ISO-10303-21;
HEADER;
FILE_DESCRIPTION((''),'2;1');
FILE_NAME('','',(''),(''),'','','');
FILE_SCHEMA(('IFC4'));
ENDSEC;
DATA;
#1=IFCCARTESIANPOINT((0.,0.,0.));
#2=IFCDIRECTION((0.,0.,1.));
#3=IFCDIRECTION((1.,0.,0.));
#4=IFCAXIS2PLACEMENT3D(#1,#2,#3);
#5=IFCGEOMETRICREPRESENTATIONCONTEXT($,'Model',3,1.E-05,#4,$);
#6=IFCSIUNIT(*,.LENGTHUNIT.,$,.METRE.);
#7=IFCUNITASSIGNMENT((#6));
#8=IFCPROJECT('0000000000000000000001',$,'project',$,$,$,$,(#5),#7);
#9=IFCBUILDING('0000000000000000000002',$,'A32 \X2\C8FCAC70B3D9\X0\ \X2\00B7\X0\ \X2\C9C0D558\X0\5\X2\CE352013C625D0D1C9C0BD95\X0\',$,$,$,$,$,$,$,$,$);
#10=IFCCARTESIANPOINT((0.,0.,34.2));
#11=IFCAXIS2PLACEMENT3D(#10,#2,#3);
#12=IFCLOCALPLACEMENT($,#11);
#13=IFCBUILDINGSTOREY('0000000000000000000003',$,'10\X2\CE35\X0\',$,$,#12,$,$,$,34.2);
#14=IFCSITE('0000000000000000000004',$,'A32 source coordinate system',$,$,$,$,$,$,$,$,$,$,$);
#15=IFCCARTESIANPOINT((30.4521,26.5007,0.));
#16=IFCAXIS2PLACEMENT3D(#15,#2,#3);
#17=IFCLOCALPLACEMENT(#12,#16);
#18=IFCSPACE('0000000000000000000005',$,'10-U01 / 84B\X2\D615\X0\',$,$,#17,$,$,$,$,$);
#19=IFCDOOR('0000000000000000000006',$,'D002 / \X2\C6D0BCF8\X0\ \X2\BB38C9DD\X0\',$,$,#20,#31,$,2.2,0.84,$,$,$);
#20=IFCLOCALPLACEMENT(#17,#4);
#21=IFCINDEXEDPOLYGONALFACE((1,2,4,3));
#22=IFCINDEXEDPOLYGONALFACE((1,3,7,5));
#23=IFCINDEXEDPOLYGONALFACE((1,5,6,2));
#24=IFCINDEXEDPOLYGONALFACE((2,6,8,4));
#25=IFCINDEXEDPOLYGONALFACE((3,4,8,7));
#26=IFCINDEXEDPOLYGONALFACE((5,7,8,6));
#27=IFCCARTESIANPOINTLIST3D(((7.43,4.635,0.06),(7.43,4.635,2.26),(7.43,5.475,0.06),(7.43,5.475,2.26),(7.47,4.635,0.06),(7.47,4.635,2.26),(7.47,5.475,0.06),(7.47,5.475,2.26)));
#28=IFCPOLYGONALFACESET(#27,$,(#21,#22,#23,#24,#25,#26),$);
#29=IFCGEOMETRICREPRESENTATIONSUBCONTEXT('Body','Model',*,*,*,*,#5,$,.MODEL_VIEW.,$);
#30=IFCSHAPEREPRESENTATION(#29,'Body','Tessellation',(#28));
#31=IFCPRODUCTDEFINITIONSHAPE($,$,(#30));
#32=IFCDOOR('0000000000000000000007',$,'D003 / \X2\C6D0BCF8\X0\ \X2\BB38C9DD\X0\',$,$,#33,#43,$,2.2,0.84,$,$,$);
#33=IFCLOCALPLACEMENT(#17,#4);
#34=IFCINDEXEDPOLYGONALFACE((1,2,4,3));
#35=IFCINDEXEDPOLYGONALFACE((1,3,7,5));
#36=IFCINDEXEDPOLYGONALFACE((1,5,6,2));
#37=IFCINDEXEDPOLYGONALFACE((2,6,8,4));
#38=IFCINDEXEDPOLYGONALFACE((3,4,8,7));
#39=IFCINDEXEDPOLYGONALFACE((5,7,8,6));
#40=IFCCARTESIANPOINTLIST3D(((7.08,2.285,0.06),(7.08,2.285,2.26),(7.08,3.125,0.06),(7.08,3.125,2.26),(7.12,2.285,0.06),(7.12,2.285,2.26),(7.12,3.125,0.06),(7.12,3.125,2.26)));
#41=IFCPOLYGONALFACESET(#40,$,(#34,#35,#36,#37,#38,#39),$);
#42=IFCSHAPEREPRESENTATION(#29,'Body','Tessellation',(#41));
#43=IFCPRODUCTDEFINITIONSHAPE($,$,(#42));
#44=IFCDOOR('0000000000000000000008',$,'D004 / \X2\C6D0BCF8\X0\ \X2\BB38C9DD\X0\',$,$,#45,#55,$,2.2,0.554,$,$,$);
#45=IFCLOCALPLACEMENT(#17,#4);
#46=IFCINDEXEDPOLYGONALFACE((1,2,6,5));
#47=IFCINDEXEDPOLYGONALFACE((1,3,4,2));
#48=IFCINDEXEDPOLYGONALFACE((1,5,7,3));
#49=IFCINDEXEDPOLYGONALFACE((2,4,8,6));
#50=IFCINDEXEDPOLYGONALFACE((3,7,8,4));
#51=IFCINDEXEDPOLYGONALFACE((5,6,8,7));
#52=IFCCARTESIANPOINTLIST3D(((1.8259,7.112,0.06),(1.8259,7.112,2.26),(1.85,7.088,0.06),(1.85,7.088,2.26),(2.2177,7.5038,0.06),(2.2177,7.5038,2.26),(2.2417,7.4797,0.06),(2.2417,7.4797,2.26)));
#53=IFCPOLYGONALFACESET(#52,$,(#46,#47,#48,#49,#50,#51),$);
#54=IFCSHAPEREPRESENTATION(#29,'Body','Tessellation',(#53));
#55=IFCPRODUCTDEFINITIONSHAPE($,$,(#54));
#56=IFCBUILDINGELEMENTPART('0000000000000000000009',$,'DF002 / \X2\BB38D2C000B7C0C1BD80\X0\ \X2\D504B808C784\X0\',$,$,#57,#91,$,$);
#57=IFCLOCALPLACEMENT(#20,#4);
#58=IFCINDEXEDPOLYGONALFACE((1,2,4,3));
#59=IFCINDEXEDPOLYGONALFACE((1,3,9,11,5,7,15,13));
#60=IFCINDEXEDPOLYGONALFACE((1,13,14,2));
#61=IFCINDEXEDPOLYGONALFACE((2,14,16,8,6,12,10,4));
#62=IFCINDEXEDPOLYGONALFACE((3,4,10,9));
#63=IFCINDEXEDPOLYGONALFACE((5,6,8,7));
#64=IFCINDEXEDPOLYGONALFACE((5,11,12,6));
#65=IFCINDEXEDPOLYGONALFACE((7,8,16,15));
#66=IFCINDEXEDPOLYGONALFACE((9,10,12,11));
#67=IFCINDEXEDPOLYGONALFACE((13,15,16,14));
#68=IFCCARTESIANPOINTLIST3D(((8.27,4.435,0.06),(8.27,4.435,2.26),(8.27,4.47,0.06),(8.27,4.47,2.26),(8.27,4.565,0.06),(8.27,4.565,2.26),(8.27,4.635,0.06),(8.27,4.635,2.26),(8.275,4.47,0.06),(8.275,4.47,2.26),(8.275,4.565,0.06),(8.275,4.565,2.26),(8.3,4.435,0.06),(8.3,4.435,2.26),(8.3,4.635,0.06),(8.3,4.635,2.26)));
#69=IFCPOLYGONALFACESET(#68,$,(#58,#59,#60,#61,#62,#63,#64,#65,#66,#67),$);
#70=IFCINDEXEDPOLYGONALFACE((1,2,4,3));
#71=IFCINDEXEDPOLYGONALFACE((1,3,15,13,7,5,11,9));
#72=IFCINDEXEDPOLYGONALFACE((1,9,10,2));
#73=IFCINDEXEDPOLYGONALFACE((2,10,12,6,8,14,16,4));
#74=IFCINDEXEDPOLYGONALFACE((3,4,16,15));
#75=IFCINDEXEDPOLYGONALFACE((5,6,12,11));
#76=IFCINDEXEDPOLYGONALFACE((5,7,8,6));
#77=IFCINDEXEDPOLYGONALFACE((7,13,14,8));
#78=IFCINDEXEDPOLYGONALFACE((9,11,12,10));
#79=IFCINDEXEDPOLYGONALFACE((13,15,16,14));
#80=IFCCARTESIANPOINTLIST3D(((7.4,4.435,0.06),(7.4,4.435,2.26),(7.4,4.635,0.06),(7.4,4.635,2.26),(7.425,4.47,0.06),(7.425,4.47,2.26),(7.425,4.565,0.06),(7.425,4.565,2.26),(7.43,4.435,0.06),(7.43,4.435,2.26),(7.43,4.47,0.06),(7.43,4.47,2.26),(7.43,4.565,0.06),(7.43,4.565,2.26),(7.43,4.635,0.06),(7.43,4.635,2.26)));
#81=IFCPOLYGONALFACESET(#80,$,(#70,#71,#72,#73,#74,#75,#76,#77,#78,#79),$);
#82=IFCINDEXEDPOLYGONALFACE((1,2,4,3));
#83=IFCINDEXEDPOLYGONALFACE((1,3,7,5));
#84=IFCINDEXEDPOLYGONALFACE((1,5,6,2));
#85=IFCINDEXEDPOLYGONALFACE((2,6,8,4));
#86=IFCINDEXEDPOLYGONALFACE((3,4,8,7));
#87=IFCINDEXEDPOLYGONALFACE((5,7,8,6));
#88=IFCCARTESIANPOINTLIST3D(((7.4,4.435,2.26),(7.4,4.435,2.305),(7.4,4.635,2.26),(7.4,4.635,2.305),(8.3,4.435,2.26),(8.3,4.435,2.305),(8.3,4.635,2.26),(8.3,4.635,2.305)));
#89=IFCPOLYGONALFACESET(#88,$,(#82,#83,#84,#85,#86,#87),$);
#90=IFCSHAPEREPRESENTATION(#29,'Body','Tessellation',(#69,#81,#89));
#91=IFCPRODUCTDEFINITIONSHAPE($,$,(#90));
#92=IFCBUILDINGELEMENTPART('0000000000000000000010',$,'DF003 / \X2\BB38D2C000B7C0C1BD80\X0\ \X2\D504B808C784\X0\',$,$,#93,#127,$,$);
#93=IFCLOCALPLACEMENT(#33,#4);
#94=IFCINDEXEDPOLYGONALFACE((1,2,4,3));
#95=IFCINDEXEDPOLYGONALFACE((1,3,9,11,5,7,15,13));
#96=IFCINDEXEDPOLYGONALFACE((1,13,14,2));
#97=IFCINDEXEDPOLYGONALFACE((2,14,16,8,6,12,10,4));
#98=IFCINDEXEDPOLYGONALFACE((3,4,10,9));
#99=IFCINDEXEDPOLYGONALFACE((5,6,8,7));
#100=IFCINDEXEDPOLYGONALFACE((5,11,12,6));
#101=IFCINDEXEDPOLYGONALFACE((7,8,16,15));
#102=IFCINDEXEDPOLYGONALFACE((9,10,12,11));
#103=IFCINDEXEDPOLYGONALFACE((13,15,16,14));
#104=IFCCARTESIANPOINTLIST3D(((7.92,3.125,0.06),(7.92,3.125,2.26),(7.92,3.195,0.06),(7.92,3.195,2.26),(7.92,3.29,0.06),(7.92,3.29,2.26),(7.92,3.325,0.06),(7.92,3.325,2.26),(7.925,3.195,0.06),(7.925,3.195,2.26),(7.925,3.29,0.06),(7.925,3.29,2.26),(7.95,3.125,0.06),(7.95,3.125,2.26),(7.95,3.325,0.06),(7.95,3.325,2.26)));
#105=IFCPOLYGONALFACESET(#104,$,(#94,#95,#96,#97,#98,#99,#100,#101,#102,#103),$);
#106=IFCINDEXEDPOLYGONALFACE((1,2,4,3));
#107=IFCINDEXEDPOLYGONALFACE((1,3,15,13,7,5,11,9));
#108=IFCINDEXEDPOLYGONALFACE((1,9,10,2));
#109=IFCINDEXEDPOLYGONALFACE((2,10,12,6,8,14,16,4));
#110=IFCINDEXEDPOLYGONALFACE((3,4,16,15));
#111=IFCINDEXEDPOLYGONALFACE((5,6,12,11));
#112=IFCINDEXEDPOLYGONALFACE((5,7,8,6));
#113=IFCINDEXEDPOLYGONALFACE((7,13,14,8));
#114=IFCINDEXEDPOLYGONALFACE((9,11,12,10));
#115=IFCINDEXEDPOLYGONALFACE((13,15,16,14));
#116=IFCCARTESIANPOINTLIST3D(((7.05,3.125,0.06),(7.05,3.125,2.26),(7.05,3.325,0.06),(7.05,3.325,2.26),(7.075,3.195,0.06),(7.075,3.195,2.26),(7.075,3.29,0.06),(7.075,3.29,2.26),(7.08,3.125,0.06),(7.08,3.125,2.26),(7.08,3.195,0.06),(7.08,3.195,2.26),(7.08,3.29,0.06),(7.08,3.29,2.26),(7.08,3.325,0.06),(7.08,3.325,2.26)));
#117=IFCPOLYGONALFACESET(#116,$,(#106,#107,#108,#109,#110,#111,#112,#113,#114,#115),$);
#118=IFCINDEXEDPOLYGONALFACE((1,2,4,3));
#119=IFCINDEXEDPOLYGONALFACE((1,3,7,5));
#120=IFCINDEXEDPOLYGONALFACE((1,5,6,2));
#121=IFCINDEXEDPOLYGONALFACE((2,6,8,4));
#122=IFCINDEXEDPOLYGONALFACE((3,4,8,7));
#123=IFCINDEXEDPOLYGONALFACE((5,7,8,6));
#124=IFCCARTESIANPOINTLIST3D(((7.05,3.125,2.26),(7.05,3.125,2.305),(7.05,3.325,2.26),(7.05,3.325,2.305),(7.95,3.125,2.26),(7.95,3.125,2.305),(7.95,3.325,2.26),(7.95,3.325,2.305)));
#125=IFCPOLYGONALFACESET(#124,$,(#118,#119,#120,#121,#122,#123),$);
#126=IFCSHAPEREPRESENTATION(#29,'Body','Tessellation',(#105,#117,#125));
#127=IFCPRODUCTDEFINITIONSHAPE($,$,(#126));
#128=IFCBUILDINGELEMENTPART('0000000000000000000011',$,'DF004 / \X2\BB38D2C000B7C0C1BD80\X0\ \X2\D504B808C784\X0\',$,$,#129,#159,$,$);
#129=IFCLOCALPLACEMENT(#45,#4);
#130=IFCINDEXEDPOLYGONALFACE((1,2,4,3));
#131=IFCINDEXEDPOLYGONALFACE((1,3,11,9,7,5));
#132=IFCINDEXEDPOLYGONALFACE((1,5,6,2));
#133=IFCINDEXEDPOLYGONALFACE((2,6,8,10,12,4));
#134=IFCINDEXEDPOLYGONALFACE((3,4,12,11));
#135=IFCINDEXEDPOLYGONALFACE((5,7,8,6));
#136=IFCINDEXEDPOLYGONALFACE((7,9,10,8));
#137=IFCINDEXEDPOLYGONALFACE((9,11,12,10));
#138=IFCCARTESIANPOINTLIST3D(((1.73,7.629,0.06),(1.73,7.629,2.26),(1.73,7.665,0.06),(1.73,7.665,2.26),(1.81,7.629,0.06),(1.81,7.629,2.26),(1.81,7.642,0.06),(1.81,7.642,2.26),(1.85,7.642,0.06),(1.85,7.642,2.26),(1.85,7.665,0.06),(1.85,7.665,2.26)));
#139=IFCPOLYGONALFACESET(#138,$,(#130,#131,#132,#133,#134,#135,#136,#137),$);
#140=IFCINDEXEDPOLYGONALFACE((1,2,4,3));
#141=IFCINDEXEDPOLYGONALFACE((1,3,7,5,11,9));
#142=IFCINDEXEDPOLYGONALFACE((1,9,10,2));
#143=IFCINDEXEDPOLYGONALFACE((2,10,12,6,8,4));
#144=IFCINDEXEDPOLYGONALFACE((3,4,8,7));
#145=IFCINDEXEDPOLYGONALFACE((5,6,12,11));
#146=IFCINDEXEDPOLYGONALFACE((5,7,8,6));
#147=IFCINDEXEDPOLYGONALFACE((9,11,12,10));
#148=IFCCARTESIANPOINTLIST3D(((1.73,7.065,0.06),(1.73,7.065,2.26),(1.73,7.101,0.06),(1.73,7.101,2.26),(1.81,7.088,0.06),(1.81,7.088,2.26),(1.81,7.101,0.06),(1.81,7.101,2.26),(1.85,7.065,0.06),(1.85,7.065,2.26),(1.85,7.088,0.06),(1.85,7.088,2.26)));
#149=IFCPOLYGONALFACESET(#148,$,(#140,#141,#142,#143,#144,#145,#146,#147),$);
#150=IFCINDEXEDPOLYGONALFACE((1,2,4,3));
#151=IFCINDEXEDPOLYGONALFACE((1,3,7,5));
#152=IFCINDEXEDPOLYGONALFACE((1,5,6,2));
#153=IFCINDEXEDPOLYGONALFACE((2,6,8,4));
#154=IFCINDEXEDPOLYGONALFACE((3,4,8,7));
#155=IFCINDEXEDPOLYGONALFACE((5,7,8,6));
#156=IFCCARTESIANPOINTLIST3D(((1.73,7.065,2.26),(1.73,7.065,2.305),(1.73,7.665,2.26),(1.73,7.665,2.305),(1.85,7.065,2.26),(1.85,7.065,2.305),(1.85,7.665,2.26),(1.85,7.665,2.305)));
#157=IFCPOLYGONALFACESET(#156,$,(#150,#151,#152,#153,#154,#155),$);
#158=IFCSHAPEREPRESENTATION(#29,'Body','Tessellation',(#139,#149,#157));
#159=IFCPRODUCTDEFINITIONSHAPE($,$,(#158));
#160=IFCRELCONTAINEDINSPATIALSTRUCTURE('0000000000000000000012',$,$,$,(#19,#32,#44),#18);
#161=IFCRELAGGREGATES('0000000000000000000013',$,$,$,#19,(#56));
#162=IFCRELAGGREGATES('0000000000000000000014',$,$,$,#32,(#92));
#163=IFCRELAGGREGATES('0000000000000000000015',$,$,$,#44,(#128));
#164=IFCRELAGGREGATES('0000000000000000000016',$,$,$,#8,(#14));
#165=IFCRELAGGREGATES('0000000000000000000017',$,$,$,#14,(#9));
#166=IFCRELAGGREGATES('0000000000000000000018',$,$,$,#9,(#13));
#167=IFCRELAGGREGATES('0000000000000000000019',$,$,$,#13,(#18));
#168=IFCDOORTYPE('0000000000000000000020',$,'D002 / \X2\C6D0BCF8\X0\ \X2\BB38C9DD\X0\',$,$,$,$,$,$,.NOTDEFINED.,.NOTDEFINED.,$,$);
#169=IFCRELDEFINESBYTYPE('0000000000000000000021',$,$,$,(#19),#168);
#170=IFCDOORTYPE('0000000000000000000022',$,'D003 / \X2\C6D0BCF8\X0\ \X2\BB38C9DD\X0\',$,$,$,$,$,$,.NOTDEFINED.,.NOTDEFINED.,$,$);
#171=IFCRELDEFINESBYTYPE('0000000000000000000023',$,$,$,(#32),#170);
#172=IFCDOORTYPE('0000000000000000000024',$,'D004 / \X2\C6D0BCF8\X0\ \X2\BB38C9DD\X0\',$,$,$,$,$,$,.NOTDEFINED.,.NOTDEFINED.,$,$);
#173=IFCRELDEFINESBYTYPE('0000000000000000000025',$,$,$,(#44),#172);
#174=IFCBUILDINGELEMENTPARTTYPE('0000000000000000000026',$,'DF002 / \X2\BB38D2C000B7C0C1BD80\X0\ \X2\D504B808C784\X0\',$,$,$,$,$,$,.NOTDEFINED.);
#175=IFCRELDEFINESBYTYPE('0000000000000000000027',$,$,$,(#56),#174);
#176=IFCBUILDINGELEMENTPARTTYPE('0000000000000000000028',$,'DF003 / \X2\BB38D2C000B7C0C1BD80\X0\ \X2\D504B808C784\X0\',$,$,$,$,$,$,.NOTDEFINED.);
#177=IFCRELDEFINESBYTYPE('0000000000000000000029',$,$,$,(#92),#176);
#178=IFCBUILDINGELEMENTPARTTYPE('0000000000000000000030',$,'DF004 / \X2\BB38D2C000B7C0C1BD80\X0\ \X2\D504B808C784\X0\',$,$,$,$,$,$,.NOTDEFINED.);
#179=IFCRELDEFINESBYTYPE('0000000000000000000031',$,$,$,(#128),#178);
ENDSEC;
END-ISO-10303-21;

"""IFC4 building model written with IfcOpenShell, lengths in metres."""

from ifc_helpers import new_model, si_unit, frame, origin, origin_with_axes, place, context, subcontext, project, spatial, polyline, outline, extrude, source, transform, mapped, type_object, type_shapes, element, aggregate, save


model = new_model("IFC4")

# Units and contexts
model_context = context("Model", 3, precision=1e-05, world=origin_with_axes())
body_context = subcontext(model_context, "Body", "Model", "MODEL_VIEW")
ifc_project = project(units=[si_unit("LENGTHUNIT", "METRE")], contexts=[model_context])

# Site, building, storey, space
storey_placement = place(None, frame((0.0, 0.0, 34.2), z_axis=(0.0, 0.0, 1.0), x_axis=(1.0, 0.0, 0.0)))
space_placement = place(storey_placement, frame((30.4521, 26.5007, 0.0), z_axis=(0.0, 0.0, 1.0), x_axis=(1.0, 0.0, 0.0)))
site = spatial("IfcSite", under=ifc_project, Name="A32 source coordinate system")
building = spatial("IfcBuilding", under=site, Name="A32 주거동 · 지하5층–옥탑지붕")
storey = spatial("IfcBuildingStorey", under=building, at=storey_placement, Name="10층", Elevation=34.2)
space = spatial("IfcSpace", under=storey, at=space_placement, Name="10-U01 / 84B형")

# Doors
door_type_1 = type_object("IfcDoorType", Name="D002 / 원본 문짝", OperationType="NOTDEFINED", PredefinedType="NOTDEFINED")
shared_shape_1 = source(origin(), body_context, "Body", "SweptSolid", [
    extrude(outline(polyline([(7.43, 4.635), (7.43, 5.475), (7.47, 5.475), (7.47, 4.635), (7.43, 4.635)])), frame((0.0, 0.0, 0.06)), (0.0, 0.0, 1.0), 2.2),
])
type_shapes(door_type_1, [shared_shape_1])
door_1_placement = place(space_placement, origin_with_axes())
door_1 = element("IfcDoor", 1, at=door_1_placement, inside=space, type_object=door_type_1, Name="D002 / 원본 문짝", OverallHeight=2.2, OverallWidth=0.84, context=body_context, shape_type="MappedRepresentation", body=[
    mapped(shared_shape_1, transform((0.0, 0.0, 0.0), scale=1.0)),
])
door_type_2 = type_object("IfcDoorType", Name="D003 / 원본 문짝", OperationType="NOTDEFINED", PredefinedType="NOTDEFINED")
shared_shape_2 = source(origin(), body_context, "Body", "SweptSolid", [
    extrude(outline(polyline([(7.12, 2.285), (7.08, 2.285), (7.08, 3.125), (7.12, 3.125), (7.12, 2.285)])), frame((0.0, 0.0, 0.06)), (0.0, 0.0, 1.0), 2.2),
])
type_shapes(door_type_2, [shared_shape_2])
door_2_placement = place(space_placement, origin_with_axes())
door_2 = element("IfcDoor", 2, at=door_2_placement, inside=space, type_object=door_type_2, Name="D003 / 원본 문짝", OverallHeight=2.2, OverallWidth=0.84, context=body_context, shape_type="MappedRepresentation", body=[
    mapped(shared_shape_2, transform((0.0, 0.0, 0.0), scale=1.0)),
])
door_type_3 = type_object("IfcDoorType", Name="D004 / 원본 문짝", OperationType="NOTDEFINED", PredefinedType="NOTDEFINED")
shared_shape_3 = source(origin(), body_context, "Body", "SweptSolid", [
    extrude(outline(polyline([(2.2177, 7.5038), (2.2417, 7.4797), (1.85, 7.088), (1.8259, 7.112), (2.2177, 7.5038)])), frame((0.0, 0.0, 0.06)), (0.0, 0.0, 1.0), 2.2),
])
type_shapes(door_type_3, [shared_shape_3])
door_3_placement = place(space_placement, origin_with_axes())
door_3 = element("IfcDoor", 3, at=door_3_placement, inside=space, type_object=door_type_3, Name="D004 / 원본 문짝", OverallHeight=2.2, OverallWidth=0.554, context=body_context, shape_type="MappedRepresentation", body=[
    mapped(shared_shape_3, transform((0.0, 0.0, 0.0), scale=1.0)),
])

# Building element parts
building_element_part_type_1 = type_object("IfcBuildingElementPartType", Name="DF002 / 문틀·상부 프레임", PredefinedType="NOTDEFINED")
shared_shape_4 = source(origin(), body_context, "Body", "SweptSolid", [
    extrude(outline(polyline([(8.3, 4.435), (8.27, 4.435), (8.27, 4.47), (8.275, 4.47), (8.275, 4.565), (8.27, 4.565), (8.27, 4.635), (8.3, 4.635), (8.3, 4.435)])), frame((0.0, 0.0, 0.06)), (0.0, 0.0, 1.0), 2.2),
    extrude(outline(polyline([(7.43, 4.635), (7.43, 4.565), (7.425, 4.565), (7.425, 4.47), (7.43, 4.47), (7.43, 4.435), (7.4, 4.435), (7.4, 4.635), (7.43, 4.635)])), frame((0.0, 0.0, 0.06)), (0.0, 0.0, 1.0), 2.2),
    extrude(outline(polyline([(7.4, 4.435), (7.4, 4.635), (8.3, 4.635), (8.3, 4.435), (7.4, 4.435)])), frame((0.0, 0.0, 2.26)), (0.0, 0.0, 1.0), 0.045),
])
type_shapes(building_element_part_type_1, [shared_shape_4])
building_element_part_1_placement = place(door_1_placement, origin_with_axes())
building_element_part_1 = element("IfcBuildingElementPart", 4, at=building_element_part_1_placement, type_object=building_element_part_type_1, Name="DF002 / 문틀·상부 프레임", context=body_context, shape_type="MappedRepresentation", body=[
    mapped(shared_shape_4, transform((0.0, 0.0, 0.0), scale=1.0)),
])
aggregate(door_1, [building_element_part_1])
building_element_part_type_2 = type_object("IfcBuildingElementPartType", Name="DF003 / 문틀·상부 프레임", PredefinedType="NOTDEFINED")
shared_shape_5 = source(origin(), body_context, "Body", "SweptSolid", [
    extrude(outline(polyline([(7.92, 3.125), (7.92, 3.195), (7.925, 3.195), (7.925, 3.29), (7.92, 3.29), (7.92, 3.325), (7.95, 3.325), (7.95, 3.125), (7.92, 3.125)])), frame((0.0, 0.0, 0.06)), (0.0, 0.0, 1.0), 2.2),
    extrude(outline(polyline([(7.05, 3.325), (7.08, 3.325), (7.08, 3.29), (7.075, 3.29), (7.075, 3.195), (7.08, 3.195), (7.08, 3.125), (7.05, 3.125), (7.05, 3.325)])), frame((0.0, 0.0, 0.06)), (0.0, 0.0, 1.0), 2.2),
    extrude(outline(polyline([(7.05, 3.125), (7.05, 3.325), (7.95, 3.325), (7.95, 3.125), (7.05, 3.125)])), frame((0.0, 0.0, 2.26)), (0.0, 0.0, 1.0), 0.045),
])
type_shapes(building_element_part_type_2, [shared_shape_5])
building_element_part_2_placement = place(door_2_placement, origin_with_axes())
building_element_part_2 = element("IfcBuildingElementPart", 5, at=building_element_part_2_placement, type_object=building_element_part_type_2, Name="DF003 / 문틀·상부 프레임", context=body_context, shape_type="MappedRepresentation", body=[
    mapped(shared_shape_5, transform((0.0, 0.0, 0.0), scale=1.0)),
])
aggregate(door_2, [building_element_part_2])
building_element_part_type_3 = type_object("IfcBuildingElementPartType", Name="DF004 / 문틀·상부 프레임", PredefinedType="NOTDEFINED")
shared_shape_6 = source(origin(), body_context, "Body", "SweptSolid", [
    extrude(outline(polyline([(1.85, 7.665), (1.85, 7.642), (1.81, 7.642), (1.81, 7.629), (1.73, 7.629), (1.73, 7.665), (1.85, 7.665)])), frame((0.0, 0.0, 0.06)), (0.0, 0.0, 1.0), 2.2),
    extrude(outline(polyline([(1.73, 7.101), (1.81, 7.101), (1.81, 7.088), (1.85, 7.088), (1.85, 7.065), (1.73, 7.065), (1.73, 7.101)])), frame((0.0, 0.0, 0.06)), (0.0, 0.0, 1.0), 2.2),
    extrude(outline(polyline([(1.73, 7.065), (1.73, 7.665), (1.85, 7.665), (1.85, 7.065), (1.73, 7.065)])), frame((0.0, 0.0, 2.26)), (0.0, 0.0, 1.0), 0.045),
])
type_shapes(building_element_part_type_3, [shared_shape_6])
building_element_part_3_placement = place(door_3_placement, origin_with_axes())
building_element_part_3 = element("IfcBuildingElementPart", 6, at=building_element_part_3_placement, type_object=building_element_part_type_3, Name="DF004 / 문틀·상부 프레임", context=body_context, shape_type="MappedRepresentation", body=[
    mapped(shared_shape_6, transform((0.0, 0.0, 0.0), scale=1.0)),
])
aggregate(door_3, [building_element_part_3])

save(model, "model.ifc")
